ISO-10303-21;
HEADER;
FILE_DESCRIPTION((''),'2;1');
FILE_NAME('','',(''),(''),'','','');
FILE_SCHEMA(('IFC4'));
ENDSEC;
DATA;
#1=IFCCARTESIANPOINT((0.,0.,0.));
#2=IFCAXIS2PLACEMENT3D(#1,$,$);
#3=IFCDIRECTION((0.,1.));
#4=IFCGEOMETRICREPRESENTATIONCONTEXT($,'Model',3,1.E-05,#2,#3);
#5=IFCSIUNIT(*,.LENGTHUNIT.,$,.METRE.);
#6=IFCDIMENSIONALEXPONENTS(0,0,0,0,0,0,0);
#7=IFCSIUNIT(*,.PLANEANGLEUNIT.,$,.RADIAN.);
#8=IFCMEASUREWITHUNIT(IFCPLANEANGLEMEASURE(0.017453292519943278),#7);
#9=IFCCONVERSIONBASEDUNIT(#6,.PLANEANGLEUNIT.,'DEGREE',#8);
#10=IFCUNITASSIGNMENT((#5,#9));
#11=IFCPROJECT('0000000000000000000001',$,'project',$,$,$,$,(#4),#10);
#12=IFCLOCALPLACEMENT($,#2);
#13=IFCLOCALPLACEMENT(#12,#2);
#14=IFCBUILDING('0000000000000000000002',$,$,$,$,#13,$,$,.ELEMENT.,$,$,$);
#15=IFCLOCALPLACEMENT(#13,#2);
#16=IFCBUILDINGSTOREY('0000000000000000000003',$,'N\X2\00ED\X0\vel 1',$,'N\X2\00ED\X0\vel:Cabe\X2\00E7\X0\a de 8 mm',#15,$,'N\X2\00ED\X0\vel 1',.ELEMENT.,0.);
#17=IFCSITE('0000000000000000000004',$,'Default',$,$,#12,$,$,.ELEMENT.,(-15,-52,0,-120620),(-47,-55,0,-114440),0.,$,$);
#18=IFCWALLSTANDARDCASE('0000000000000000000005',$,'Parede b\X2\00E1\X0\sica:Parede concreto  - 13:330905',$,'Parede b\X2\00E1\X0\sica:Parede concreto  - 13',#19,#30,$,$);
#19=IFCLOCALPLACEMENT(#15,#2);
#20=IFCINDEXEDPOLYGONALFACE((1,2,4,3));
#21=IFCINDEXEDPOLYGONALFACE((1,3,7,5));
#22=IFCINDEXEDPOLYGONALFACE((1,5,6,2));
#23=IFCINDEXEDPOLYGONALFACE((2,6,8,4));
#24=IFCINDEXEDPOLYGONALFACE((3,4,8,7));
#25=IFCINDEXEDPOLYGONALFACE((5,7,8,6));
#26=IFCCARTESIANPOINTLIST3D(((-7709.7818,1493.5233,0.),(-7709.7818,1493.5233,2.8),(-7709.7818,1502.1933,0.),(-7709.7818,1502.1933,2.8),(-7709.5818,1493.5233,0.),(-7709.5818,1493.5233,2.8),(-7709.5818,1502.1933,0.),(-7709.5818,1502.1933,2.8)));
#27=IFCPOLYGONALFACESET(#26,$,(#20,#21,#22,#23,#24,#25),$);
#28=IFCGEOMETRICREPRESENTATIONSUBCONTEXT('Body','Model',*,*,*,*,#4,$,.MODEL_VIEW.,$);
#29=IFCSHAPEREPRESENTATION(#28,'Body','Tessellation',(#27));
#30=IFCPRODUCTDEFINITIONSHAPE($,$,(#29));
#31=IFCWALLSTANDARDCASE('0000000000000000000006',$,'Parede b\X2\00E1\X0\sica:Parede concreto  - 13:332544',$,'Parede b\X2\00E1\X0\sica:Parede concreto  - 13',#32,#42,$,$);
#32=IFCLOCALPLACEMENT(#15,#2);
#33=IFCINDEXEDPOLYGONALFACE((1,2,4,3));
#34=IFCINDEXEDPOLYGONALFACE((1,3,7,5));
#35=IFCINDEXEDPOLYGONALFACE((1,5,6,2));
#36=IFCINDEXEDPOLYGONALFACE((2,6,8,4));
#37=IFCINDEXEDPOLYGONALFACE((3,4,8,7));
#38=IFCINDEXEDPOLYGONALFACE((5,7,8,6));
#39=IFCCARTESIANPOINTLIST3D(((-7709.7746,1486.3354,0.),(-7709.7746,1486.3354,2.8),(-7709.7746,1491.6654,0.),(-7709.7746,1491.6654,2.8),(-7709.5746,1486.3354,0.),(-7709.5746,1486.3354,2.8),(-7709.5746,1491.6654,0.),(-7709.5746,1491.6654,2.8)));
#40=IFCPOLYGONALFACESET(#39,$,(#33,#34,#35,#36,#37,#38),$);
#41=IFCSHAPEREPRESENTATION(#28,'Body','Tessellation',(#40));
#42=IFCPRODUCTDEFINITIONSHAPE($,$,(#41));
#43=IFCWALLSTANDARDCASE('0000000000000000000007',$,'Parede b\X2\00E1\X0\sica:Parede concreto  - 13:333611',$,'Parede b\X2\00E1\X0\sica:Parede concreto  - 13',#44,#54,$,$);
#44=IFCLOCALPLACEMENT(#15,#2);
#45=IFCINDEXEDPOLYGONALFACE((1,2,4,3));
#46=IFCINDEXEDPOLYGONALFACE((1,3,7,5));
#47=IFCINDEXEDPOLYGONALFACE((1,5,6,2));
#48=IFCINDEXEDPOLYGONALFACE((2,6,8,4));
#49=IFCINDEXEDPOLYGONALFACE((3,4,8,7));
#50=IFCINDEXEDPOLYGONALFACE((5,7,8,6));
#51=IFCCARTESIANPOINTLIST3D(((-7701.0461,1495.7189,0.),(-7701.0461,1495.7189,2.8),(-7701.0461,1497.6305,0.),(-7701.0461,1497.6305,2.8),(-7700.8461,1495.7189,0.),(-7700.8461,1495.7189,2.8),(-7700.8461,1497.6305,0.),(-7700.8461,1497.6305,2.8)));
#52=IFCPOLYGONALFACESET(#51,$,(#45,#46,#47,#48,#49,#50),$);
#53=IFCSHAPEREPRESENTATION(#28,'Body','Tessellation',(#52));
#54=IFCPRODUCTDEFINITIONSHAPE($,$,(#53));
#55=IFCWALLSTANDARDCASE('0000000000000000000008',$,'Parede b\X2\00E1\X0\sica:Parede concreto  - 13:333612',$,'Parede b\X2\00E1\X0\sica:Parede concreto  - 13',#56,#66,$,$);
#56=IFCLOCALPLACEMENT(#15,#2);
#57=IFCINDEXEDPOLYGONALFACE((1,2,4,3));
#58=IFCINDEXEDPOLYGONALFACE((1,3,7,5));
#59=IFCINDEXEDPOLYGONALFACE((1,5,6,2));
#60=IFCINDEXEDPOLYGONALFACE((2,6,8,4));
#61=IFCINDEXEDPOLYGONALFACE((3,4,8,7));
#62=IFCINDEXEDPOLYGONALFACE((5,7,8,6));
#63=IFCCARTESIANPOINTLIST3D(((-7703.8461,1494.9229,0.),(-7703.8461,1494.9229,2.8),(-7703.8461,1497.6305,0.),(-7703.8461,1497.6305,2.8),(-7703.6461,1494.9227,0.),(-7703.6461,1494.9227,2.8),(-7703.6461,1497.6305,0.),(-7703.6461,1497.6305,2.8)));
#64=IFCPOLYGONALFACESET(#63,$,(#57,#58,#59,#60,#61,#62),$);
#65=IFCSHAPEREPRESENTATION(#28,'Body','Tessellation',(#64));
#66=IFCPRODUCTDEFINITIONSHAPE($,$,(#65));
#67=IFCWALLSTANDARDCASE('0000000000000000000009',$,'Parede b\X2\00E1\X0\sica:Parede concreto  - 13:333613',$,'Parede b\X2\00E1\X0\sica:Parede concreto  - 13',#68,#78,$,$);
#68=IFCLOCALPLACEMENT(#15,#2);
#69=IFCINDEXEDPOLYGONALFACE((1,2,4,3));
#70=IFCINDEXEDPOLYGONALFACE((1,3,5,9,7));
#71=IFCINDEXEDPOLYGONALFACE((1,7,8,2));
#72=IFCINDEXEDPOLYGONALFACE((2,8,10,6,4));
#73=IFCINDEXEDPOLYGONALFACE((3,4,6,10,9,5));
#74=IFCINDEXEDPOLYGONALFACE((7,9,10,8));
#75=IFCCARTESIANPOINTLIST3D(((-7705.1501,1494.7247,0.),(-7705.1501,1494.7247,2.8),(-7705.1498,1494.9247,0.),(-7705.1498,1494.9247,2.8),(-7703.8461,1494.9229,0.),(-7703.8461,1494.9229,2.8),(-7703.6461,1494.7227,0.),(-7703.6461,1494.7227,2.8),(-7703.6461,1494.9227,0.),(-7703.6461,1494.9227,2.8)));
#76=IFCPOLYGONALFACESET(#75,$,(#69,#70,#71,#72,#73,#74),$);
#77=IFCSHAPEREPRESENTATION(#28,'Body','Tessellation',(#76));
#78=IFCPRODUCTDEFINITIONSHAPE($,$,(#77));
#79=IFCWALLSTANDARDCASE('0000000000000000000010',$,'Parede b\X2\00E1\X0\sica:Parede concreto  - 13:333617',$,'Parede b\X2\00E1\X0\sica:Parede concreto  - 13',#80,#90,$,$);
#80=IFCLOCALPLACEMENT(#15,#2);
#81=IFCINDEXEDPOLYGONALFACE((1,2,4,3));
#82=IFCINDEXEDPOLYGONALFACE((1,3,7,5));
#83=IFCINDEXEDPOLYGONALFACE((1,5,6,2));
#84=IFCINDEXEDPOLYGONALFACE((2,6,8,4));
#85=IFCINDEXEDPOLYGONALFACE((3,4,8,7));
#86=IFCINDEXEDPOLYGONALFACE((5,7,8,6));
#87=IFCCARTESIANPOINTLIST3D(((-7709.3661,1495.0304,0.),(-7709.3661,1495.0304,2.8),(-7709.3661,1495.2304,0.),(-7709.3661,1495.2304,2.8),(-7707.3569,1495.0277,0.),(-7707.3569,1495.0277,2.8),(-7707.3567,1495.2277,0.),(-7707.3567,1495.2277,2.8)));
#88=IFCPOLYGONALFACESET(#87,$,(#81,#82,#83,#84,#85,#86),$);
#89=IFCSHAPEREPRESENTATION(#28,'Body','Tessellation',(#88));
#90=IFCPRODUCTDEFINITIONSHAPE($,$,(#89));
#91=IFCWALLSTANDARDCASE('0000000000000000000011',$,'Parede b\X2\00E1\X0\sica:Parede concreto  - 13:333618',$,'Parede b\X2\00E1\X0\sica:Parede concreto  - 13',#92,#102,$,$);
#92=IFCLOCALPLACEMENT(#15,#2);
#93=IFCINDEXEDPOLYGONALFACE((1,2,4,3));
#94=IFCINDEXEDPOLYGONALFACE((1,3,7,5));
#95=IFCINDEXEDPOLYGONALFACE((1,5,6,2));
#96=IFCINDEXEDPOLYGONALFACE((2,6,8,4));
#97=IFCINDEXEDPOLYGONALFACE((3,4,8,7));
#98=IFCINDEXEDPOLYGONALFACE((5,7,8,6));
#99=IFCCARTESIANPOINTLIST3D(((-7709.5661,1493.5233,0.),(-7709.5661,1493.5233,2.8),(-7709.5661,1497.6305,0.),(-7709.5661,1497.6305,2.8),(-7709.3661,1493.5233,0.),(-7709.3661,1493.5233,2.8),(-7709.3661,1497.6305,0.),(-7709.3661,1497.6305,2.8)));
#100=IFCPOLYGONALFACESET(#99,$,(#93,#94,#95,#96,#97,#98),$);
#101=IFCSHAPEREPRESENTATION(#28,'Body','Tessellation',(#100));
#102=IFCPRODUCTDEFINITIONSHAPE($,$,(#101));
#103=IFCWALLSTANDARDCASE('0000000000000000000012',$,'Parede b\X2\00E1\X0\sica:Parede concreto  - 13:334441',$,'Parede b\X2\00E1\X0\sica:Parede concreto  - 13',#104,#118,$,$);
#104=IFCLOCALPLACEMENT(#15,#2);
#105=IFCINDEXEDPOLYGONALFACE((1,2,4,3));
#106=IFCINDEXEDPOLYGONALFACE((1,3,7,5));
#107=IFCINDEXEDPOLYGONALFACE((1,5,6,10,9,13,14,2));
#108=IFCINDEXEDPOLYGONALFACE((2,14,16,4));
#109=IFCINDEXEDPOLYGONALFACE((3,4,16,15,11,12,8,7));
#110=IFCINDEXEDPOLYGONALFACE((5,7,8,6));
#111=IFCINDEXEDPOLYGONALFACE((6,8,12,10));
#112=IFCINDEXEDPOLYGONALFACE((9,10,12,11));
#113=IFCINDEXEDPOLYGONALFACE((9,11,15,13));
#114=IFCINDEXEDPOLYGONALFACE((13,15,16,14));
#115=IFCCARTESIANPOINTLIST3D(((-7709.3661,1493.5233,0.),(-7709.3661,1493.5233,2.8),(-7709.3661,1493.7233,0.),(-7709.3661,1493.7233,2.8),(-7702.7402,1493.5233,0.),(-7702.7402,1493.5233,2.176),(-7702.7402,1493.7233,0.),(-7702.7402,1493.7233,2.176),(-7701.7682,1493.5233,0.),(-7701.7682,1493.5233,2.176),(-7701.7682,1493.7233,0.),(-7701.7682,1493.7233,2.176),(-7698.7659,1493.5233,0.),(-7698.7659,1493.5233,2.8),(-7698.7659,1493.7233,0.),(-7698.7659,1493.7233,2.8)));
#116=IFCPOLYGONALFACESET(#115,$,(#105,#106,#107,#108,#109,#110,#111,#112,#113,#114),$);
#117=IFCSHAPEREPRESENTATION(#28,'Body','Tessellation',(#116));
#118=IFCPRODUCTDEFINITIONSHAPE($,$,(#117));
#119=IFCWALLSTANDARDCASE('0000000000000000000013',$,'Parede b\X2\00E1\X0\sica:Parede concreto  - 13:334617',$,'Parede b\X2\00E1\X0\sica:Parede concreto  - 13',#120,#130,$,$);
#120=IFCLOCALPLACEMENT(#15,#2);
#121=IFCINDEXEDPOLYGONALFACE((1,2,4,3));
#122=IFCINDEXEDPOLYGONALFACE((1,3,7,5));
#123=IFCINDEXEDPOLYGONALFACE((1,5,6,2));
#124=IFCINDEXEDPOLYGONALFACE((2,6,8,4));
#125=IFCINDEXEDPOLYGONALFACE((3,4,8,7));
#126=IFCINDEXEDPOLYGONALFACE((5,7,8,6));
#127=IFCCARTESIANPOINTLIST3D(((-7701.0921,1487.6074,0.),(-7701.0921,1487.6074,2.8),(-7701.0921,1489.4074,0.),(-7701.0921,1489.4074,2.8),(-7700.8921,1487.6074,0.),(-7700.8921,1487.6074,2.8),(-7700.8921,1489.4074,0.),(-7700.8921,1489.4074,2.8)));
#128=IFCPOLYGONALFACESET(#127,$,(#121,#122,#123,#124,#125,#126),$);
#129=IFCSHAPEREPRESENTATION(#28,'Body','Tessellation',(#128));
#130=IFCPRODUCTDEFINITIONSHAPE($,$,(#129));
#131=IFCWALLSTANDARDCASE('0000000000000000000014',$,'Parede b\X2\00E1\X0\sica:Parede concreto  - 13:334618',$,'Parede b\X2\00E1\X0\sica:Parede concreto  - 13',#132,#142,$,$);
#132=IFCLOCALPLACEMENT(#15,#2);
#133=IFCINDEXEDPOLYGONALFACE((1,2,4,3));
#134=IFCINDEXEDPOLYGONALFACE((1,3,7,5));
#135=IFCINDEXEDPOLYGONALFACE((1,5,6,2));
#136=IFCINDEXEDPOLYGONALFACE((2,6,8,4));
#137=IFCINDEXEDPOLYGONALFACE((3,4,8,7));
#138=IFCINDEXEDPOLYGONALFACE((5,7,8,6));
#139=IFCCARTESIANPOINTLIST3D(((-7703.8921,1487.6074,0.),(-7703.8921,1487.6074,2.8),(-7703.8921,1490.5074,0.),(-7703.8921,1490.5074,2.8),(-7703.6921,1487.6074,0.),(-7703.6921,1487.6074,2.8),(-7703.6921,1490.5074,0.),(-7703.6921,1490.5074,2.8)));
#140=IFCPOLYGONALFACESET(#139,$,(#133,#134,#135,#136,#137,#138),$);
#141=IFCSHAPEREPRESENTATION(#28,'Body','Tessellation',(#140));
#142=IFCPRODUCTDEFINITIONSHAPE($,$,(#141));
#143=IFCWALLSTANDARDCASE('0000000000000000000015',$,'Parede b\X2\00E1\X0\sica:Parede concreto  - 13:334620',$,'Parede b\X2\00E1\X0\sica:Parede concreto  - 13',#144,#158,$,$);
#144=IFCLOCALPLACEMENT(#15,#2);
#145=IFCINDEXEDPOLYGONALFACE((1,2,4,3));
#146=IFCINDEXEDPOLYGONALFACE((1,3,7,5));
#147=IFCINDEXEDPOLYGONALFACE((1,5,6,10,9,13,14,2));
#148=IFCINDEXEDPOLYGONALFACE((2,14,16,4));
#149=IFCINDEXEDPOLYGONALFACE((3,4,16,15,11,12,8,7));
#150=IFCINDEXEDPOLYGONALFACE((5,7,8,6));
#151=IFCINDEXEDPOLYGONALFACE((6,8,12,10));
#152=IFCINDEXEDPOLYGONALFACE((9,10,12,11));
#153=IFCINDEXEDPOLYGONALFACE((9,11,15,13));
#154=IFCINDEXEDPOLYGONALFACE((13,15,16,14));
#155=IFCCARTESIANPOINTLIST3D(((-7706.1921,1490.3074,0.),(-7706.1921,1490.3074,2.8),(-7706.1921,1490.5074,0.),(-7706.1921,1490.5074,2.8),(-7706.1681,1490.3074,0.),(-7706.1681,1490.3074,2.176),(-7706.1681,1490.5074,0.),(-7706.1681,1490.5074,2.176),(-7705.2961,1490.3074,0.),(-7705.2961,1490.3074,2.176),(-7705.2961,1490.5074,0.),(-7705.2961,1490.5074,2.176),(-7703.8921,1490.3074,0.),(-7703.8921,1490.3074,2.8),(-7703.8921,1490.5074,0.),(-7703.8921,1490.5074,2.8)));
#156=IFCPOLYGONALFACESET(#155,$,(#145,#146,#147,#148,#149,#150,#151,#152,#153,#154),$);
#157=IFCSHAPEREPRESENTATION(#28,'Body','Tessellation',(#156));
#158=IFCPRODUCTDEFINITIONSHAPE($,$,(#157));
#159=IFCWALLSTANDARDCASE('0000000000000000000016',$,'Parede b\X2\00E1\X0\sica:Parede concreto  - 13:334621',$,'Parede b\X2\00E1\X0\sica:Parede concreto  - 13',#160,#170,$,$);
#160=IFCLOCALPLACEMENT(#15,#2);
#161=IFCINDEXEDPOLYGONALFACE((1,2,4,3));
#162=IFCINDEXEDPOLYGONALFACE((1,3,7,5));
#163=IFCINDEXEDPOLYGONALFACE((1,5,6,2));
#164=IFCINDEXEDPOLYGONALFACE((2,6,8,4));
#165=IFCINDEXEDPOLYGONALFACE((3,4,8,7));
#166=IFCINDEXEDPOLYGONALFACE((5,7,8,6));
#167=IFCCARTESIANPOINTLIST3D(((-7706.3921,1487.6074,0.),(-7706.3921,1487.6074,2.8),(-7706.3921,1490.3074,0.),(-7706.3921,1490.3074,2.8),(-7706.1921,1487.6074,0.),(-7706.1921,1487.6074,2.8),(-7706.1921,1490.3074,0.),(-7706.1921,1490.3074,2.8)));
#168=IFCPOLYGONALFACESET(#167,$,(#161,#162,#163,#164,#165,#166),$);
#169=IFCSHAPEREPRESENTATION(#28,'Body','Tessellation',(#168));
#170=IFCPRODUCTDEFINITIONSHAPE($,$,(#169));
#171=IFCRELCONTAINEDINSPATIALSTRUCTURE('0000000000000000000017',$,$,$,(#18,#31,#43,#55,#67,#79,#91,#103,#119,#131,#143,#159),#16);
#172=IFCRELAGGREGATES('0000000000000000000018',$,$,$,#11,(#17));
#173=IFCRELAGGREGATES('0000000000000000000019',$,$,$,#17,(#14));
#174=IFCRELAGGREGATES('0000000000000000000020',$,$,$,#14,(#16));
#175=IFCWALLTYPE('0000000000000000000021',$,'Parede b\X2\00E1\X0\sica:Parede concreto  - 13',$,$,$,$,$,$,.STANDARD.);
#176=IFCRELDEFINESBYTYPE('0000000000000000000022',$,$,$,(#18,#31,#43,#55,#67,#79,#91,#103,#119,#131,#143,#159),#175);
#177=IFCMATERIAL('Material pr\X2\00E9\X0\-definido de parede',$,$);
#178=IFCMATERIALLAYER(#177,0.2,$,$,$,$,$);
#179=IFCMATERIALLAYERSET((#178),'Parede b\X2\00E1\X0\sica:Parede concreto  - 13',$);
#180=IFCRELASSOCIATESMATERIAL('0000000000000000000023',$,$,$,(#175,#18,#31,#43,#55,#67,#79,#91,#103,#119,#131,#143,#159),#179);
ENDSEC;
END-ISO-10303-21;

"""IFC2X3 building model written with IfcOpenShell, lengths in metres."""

from ifc_helpers import new_model, entity, si_unit, converted_unit, direction, frame, frame_2d, origin, place, context, subcontext, project, spatial, polyline, rectangle, outline, extrude, material, layer, layer_set, layer_usage, type_object, element, save


model = new_model("IFC2X3")

# Units and contexts
model_context = context("Model", 3, precision=1e-05, world=origin(), true_north=direction((0.0, 1.0)))
body_context = subcontext(model_context, "Body", "Model", "MODEL_VIEW")
ifc_project = project(units=[si_unit("LENGTHUNIT", "METRE"), converted_unit("PLANEANGLEUNIT", "DEGREE", entity("IfcPlaneAngleMeasure", 0.017453292519943278), si_unit("PLANEANGLEUNIT", "RADIAN"), dimensions=[0, 0, 0, 0, 0, 0, 0])], contexts=[model_context])

# Site, building, storey
site_placement = place(None, origin())
site = spatial("IfcSite", under=ifc_project, at=site_placement, Name="Default", CompositionType="ELEMENT", RefLatitude=(-15, -52, 0, -120620), RefLongitude=(-47, -55, 0, -114440), RefElevation=0.0)
building_placement = place(site_placement, origin())
building = spatial("IfcBuilding", under=site, at=building_placement, CompositionType="ELEMENT")
storey_placement = place(building_placement, origin())
storey = spatial("IfcBuildingStorey", under=building, at=storey_placement, Name="Nível 1", ObjectType="Nível:Cabeça de 8 mm", LongName="Nível 1", CompositionType="ELEMENT", Elevation=0.0)

# Walls
ifc_material = material(Name="Material pré-definido de parede")
ifc_layer = layer(ifc_material, 0.2)
ifc_layer_set = layer_set([ifc_layer], Name="Parede básica:Parede concreto  - 13")
ifc_layer_usage_1 = layer_usage(ifc_layer_set, "AXIS2", "NEGATIVE", 0.1)
wall_type = type_object("IfcWallType", Name="Parede básica:Parede concreto  - 13", PredefinedType="STANDARD", material=ifc_layer_set)
wall_1_placement = place(storey_placement, frame((-7709.6818, 1502.1933, 0.0), z_axis=(0.0, 0.0, 1.0), x_axis=(0.0, -1.0, 0.0)))
element("IfcWallStandardCase", 1, at=wall_1_placement, inside=storey, type_object=wall_type, material=ifc_layer_usage_1, Name="Parede básica:Parede concreto  - 13:330905", ObjectType="Parede básica:Parede concreto  - 13", context=body_context, shape_type="SweptSolid", body=[
    extrude(rectangle(XDim=8.67, YDim=0.2, at=frame_2d((4.335, 0.0), x_axis=(-1.0, 0.0))), origin(), (0.0, 0.0, 1.0), 2.8),
])
ifc_layer_usage_2 = layer_usage(ifc_layer_set, "AXIS2", "NEGATIVE", 0.1)
wall_2_placement = place(storey_placement, frame((-7709.6746, 1486.3354, 0.0), z_axis=(0.0, 0.0, 1.0), x_axis=(0.0, 1.0, 0.0)))
element("IfcWallStandardCase", 2, at=wall_2_placement, inside=storey, type_object=wall_type, material=ifc_layer_usage_2, Name="Parede básica:Parede concreto  - 13:332544", ObjectType="Parede básica:Parede concreto  - 13", context=body_context, shape_type="SweptSolid", body=[
    extrude(rectangle(XDim=5.33, YDim=0.2, at=frame_2d((2.665, 0.0), x_axis=(-1.0, 0.0))), origin(), (0.0, 0.0, 1.0), 2.8),
])
ifc_layer_usage_3 = layer_usage(ifc_layer_set, "AXIS2", "POSITIVE", -0.1)
wall_3_placement = place(storey_placement, frame((-7700.9461, 1497.6305, 0.0), z_axis=(0.0, 0.0, 1.0), x_axis=(0.0, -1.0, 0.0)))
element("IfcWallStandardCase", 3, at=wall_3_placement, inside=storey, type_object=wall_type, material=ifc_layer_usage_3, Name="Parede básica:Parede concreto  - 13:333611", ObjectType="Parede básica:Parede concreto  - 13", context=body_context, shape_type="SweptSolid", body=[
    extrude(rectangle(XDim=1.9116, YDim=0.2, at=frame_2d((0.9558, 0.0), x_axis=(-1.0, 0.0))), origin(), (0.0, 0.0, 1.0), 2.8),
])
ifc_layer_usage_4 = layer_usage(ifc_layer_set, "AXIS2", "POSITIVE", -0.1)
wall_4_placement = place(storey_placement, frame((-7703.7461, 1497.6305, 0.0), z_axis=(0.0, 0.0, 1.0), x_axis=(0.0, -1.0, 0.0)))
element("IfcWallStandardCase", 4, at=wall_4_placement, inside=storey, type_object=wall_type, material=ifc_layer_usage_4, Name="Parede básica:Parede concreto  - 13:333612", ObjectType="Parede básica:Parede concreto  - 13", context=body_context, shape_type="SweptSolid", body=[
    extrude(outline(polyline([(2.7076, -0.1), (2.7078, 0.1), (0.0, 0.1), (0.0, -0.1), (2.7076, -0.1)])), origin(), (0.0, 0.0, 1.0), 2.8),
])
ifc_layer_usage_5 = layer_usage(ifc_layer_set, "AXIS2", "POSITIVE", -0.1)
wall_5_placement = place(storey_placement, frame((-7703.6459, 1494.8227, 0.0), z_axis=(0.0, 0.0, 1.0), x_axis=(-0.999999, 0.001347, 0.0)))
element("IfcWallStandardCase", 5, at=wall_5_placement, inside=storey, type_object=wall_type, material=ifc_layer_usage_5, Name="Parede básica:Parede concreto  - 13:333613", ObjectType="Parede básica:Parede concreto  - 13", context=body_context, shape_type="SweptSolid", body=[
    extrude(outline(polyline([(1.504, -0.1), (1.504, 0.1), (0.0, 0.1), (0.0003, -0.1), (0.2003, -0.1), (1.504, -0.1)])), origin(), (0.0, 0.0, 1.0), 2.8),
])
ifc_layer_usage_6 = layer_usage(ifc_layer_set, "AXIS2", "POSITIVE", -0.1)
wall_6_placement = place(storey_placement, frame((-7707.3568, 1495.1277, 0.0), z_axis=(0.0, 0.0, 1.0), x_axis=(-0.999999, 0.001347, 0.0)))
element("IfcWallStandardCase", 6, at=wall_6_placement, inside=storey, type_object=wall_type, material=ifc_layer_usage_6, Name="Parede básica:Parede concreto  - 13:333617", ObjectType="Parede básica:Parede concreto  - 13", context=body_context, shape_type="SweptSolid", body=[
    extrude(outline(polyline([(2.0094, -0.1), (2.0091, 0.1), (0.0, 0.1), (0.0, -0.1), (2.0094, -0.1)])), origin(), (0.0, 0.0, 1.0), 2.8),
])
ifc_layer_usage_7 = layer_usage(ifc_layer_set, "AXIS2", "POSITIVE", -0.1)
wall_7_placement = place(storey_placement, frame((-7709.4661, 1497.6305, 0.0), z_axis=(0.0, 0.0, 1.0), x_axis=(0.0, -1.0, 0.0)))
element("IfcWallStandardCase", 7, at=wall_7_placement, inside=storey, type_object=wall_type, material=ifc_layer_usage_7, Name="Parede básica:Parede concreto  - 13:333618", ObjectType="Parede básica:Parede concreto  - 13", context=body_context, shape_type="SweptSolid", body=[
    extrude(rectangle(XDim=4.1072, YDim=0.2, at=frame_2d((2.0536, 0.0), x_axis=(-1.0, 0.0))), origin(), (0.0, 0.0, 1.0), 2.8),
])

# Wall, opening
ifc_layer_usage_8 = layer_usage(ifc_layer_set, "AXIS2", "NEGATIVE", 0.1)
wall_8_placement = place(storey_placement, frame((-7698.7659, 1493.6233, 0.0), z_axis=(0.0, 0.0, 1.0), x_axis=(-1.0, 0.0, 0.0)))
wall_8 = element("IfcWallStandardCase", 8, at=wall_8_placement, inside=storey, type_object=wall_type, material=ifc_layer_usage_8, Name="Parede básica:Parede concreto  - 13:334441", ObjectType="Parede básica:Parede concreto  - 13", context=body_context, shape_type="SweptSolid", body=[
    extrude(rectangle(XDim=10.6001, YDim=0.2, at=frame_2d((5.3001, 0.0), x_axis=(-1.0, 0.0))), origin(), (0.0, 0.0, 1.0), 2.8),
])
opening_1_placement = place(wall_8_placement, origin())
element("IfcOpeningElement", 9, at=opening_1_placement, cuts=wall_8, ObjectType="Opening", context=body_context, shape_type="SweptSolid", body=[
    extrude(rectangle(XDim=2.176, YDim=0.972, at=frame_2d((0.0, 0.0), x_axis=(0.0, 1.0))), frame((3.4882, 0.1, 1.088), z_axis=(0.0, -1.0, 0.0), x_axis=(1.0, 0.0, 0.0)), (0.0, 0.0, 1.0), 0.2),
])

# Walls
ifc_layer_usage_9 = layer_usage(ifc_layer_set, "AXIS2", "POSITIVE", -0.1)
wall_9_placement = place(storey_placement, frame((-7700.9921, 1489.4074, 0.0), z_axis=(0.0, 0.0, 1.0), x_axis=(0.0, -1.0, 0.0)))
element("IfcWallStandardCase", 10, at=wall_9_placement, inside=storey, type_object=wall_type, material=ifc_layer_usage_9, Name="Parede básica:Parede concreto  - 13:334617", ObjectType="Parede básica:Parede concreto  - 13", context=body_context, shape_type="SweptSolid", body=[
    extrude(rectangle(XDim=1.8, YDim=0.2, at=frame_2d((0.9, 0.0), x_axis=(-1.0, 0.0))), origin(), (0.0, 0.0, 1.0), 2.8),
])
ifc_layer_usage_10 = layer_usage(ifc_layer_set, "AXIS2", "POSITIVE", -0.1)
wall_10_placement = place(storey_placement, frame((-7703.7921, 1490.5074, 0.0), z_axis=(0.0, 0.0, 1.0), x_axis=(0.0, -1.0, 0.0)))
element("IfcWallStandardCase", 11, at=wall_10_placement, inside=storey, type_object=wall_type, material=ifc_layer_usage_10, Name="Parede básica:Parede concreto  - 13:334618", ObjectType="Parede básica:Parede concreto  - 13", context=body_context, shape_type="SweptSolid", body=[
    extrude(rectangle(XDim=2.9, YDim=0.2, at=frame_2d((1.45, 0.0), x_axis=(-1.0, 0.0))), origin(), (0.0, 0.0, 1.0), 2.8),
])

# Wall, opening
ifc_layer_usage_11 = layer_usage(ifc_layer_set, "AXIS2", "POSITIVE", -0.1)
wall_11_placement = place(storey_placement, frame((-7703.8921, 1490.4074, 0.0), z_axis=(0.0, 0.0, 1.0), x_axis=(-1.0, 0.0, 0.0)))
wall_11 = element("IfcWallStandardCase", 12, at=wall_11_placement, inside=storey, type_object=wall_type, material=ifc_layer_usage_11, Name="Parede básica:Parede concreto  - 13:334620", ObjectType="Parede básica:Parede concreto  - 13", context=body_context, shape_type="SweptSolid", body=[
    extrude(rectangle(XDim=2.3, YDim=0.2, at=frame_2d((1.15, 0.0), x_axis=(-1.0, 0.0))), origin(), (0.0, 0.0, 1.0), 2.8),
])
opening_2_placement = place(wall_11_placement, origin())
element("IfcOpeningElement", 13, at=opening_2_placement, cuts=wall_11, ObjectType="Opening", context=body_context, shape_type="SweptSolid", body=[
    extrude(rectangle(XDim=2.176, YDim=0.872, at=frame_2d((0.0, 0.0), x_axis=(0.0, 1.0))), frame((1.84, 0.1, 1.088), z_axis=(0.0, -1.0, 0.0), x_axis=(1.0, 0.0, 0.0)), (0.0, 0.0, 1.0), 0.2),
])

# Wall
ifc_layer_usage_12 = layer_usage(ifc_layer_set, "AXIS2", "POSITIVE", -0.1)
wall_12_placement = place(storey_placement, frame((-7706.2921, 1490.3074, 0.0), z_axis=(0.0, 0.0, 1.0), x_axis=(0.0, -1.0, 0.0)))
element("IfcWallStandardCase", 14, at=wall_12_placement, inside=storey, type_object=wall_type, material=ifc_layer_usage_12, Name="Parede básica:Parede concreto  - 13:334621", ObjectType="Parede básica:Parede concreto  - 13", context=body_context, shape_type="SweptSolid", body=[
    extrude(rectangle(XDim=2.7, YDim=0.2, at=frame_2d((1.35, 0.0), x_axis=(-1.0, 0.0))), origin(), (0.0, 0.0, 1.0), 2.8),
])

save(model, "model.ifc")
